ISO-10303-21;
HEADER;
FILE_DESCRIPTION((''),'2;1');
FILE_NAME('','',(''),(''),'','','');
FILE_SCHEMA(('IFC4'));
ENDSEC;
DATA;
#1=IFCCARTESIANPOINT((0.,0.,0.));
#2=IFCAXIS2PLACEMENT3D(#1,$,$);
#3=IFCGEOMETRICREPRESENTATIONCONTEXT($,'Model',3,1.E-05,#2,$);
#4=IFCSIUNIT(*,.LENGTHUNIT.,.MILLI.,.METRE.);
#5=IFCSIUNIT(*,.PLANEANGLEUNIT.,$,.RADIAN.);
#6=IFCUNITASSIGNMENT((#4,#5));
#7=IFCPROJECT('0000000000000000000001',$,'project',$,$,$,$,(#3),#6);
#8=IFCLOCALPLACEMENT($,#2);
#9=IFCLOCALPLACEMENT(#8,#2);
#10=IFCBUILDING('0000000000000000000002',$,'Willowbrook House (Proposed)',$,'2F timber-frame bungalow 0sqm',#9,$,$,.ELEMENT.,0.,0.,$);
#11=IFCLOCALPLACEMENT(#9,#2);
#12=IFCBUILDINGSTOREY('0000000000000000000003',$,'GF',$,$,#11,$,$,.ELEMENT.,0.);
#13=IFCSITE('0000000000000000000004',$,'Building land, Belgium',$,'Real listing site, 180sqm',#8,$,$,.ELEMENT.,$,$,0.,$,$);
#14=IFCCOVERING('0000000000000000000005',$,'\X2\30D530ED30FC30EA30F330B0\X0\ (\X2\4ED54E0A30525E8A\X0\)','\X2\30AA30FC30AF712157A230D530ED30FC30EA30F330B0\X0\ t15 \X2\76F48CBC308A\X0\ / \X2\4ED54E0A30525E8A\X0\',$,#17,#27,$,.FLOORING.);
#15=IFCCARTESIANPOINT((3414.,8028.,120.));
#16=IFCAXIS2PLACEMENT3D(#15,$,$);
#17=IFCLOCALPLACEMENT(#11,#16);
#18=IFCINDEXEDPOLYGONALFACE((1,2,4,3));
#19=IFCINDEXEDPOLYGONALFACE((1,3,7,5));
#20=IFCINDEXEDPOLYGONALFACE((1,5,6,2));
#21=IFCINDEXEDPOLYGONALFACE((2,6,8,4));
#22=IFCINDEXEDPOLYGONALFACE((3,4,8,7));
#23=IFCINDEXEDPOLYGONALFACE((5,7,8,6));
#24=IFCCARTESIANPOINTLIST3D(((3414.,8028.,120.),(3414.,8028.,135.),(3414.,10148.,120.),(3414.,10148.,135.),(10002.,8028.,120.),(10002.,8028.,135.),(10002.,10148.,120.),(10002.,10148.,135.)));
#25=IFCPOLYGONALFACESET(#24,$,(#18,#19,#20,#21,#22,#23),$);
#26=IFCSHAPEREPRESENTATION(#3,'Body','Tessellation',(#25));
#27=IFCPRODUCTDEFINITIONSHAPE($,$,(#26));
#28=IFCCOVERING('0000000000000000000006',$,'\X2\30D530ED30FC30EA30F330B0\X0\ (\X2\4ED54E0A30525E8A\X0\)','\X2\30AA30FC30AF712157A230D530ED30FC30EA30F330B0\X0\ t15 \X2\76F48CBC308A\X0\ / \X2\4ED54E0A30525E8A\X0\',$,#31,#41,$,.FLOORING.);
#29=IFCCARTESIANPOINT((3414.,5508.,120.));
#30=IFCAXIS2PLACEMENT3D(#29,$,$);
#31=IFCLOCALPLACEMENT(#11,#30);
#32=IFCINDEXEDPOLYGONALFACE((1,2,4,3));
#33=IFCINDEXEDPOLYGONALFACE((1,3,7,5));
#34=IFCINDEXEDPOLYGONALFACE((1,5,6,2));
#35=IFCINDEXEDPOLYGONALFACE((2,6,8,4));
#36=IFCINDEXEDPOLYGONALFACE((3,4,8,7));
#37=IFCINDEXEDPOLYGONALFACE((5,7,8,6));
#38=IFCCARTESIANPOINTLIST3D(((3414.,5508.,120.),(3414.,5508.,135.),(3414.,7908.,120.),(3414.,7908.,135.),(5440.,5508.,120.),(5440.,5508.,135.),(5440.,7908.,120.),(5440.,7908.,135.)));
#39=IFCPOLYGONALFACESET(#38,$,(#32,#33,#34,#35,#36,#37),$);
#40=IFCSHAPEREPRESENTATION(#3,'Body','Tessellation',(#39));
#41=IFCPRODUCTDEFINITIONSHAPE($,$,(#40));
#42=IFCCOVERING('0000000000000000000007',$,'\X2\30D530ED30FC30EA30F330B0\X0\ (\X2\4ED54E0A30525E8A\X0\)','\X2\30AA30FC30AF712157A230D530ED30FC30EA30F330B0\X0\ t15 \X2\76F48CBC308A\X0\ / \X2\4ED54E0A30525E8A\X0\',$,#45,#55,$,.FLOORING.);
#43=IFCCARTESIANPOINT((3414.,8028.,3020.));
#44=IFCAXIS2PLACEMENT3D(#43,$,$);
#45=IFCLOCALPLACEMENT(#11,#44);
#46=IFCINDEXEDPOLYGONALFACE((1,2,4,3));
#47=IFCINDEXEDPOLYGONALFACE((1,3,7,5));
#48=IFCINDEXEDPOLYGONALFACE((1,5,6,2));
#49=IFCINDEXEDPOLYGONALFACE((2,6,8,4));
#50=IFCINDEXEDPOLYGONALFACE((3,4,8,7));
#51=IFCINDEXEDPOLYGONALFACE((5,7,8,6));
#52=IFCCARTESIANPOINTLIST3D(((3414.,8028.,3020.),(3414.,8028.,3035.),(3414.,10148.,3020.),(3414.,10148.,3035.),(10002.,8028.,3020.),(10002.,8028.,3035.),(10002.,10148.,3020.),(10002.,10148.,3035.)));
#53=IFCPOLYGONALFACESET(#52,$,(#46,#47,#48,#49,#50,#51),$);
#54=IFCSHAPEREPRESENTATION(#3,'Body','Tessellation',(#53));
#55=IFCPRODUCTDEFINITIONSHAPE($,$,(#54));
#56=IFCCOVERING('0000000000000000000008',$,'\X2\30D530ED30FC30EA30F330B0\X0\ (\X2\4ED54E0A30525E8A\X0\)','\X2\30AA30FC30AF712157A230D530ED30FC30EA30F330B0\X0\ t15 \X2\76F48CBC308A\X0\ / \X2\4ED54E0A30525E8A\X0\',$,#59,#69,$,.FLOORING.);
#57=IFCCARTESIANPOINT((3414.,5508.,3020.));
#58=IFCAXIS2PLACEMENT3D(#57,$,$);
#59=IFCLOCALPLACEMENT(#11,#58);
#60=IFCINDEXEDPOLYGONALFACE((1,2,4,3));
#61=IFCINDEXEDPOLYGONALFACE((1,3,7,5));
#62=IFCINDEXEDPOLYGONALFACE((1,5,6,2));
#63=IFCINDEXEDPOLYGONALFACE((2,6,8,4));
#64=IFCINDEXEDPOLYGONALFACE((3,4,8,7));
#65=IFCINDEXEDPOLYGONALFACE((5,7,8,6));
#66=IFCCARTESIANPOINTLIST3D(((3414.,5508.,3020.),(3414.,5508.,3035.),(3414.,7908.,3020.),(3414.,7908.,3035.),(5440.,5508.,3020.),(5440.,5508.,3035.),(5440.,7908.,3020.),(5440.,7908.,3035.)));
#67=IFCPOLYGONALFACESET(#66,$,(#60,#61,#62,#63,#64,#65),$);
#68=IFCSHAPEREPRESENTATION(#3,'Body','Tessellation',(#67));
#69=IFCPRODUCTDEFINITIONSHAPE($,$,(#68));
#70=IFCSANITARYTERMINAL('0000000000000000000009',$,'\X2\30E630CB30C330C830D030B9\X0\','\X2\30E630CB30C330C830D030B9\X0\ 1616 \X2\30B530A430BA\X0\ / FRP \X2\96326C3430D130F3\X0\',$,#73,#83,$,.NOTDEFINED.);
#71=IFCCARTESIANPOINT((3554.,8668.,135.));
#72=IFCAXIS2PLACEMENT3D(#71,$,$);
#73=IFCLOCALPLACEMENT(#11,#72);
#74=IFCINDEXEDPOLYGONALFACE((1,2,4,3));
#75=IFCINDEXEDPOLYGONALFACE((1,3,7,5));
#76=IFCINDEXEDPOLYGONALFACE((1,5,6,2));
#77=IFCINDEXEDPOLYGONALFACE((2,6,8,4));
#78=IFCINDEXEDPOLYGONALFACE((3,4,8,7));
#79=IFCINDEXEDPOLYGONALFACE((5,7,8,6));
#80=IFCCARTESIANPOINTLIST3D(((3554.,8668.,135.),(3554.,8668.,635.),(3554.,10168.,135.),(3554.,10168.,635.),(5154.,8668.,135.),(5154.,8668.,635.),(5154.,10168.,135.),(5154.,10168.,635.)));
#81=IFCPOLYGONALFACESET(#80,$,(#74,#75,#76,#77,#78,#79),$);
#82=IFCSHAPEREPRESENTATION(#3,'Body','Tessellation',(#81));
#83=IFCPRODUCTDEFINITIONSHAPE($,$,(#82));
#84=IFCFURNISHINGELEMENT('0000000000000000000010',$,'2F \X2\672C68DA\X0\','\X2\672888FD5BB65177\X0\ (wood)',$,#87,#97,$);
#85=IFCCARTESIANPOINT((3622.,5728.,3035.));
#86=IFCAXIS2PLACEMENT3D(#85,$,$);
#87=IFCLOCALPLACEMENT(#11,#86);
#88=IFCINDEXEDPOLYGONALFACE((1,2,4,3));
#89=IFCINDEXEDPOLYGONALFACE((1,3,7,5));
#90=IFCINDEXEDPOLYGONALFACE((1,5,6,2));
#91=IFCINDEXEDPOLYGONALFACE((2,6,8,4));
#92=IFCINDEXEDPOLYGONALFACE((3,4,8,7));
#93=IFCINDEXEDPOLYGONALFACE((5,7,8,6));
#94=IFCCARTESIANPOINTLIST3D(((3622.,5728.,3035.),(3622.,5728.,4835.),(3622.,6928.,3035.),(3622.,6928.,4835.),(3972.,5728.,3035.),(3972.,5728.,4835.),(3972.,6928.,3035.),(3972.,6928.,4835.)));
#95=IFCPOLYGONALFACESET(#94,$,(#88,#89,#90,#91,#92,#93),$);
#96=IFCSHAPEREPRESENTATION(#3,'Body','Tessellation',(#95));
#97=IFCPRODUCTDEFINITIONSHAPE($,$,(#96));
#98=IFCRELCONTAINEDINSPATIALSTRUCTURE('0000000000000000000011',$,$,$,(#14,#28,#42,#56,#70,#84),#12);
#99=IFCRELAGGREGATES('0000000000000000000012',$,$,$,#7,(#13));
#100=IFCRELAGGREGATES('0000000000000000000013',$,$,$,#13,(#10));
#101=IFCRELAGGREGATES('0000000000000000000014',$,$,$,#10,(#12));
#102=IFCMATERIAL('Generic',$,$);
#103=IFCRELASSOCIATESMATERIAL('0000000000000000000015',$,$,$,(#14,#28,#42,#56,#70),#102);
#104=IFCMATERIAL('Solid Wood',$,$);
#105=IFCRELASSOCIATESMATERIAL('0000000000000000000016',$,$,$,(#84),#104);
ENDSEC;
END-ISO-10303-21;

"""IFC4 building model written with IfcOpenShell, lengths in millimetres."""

from ifc_helpers import new_model, si_unit, frame, frame_2d, origin, place, context, project, spatial, rectangle, extrude, material, element, save


model = new_model("IFC4")

# Units and contexts
model_context = context("Model", 3, precision=1e-05, world=origin())
ifc_project = project(units=[si_unit("LENGTHUNIT", "METRE", prefix="MILLI"), si_unit("PLANEANGLEUNIT", "RADIAN")], contexts=[model_context])

# Site, building, storey
site_placement = place(None, origin())
site = spatial("IfcSite", under=ifc_project, at=site_placement, Name="Building land, Belgium", ObjectType="Real listing site, 180sqm", CompositionType="ELEMENT", RefElevation=0.0)
building_placement = place(site_placement, origin())
building = spatial("IfcBuilding", under=site, at=building_placement, Name="Willowbrook House (Proposed)", ObjectType="2F timber-frame bungalow 0sqm", CompositionType="ELEMENT", ElevationOfRefHeight=0.0, ElevationOfTerrain=0.0)
storey_placement = place(building_placement, origin())
storey = spatial("IfcBuildingStorey", under=building, at=storey_placement, Name="GF", CompositionType="ELEMENT", Elevation=0.0)

# Shared definitions
ifc_material_1 = material(Name="Solid Wood")

# Coverings
ifc_material_2 = material(Name="Generic")
covering_1_placement = place(storey_placement, frame((3414.0, 8028.0, 120.0)))
element("IfcCovering", 1, at=covering_1_placement, inside=storey, material=ifc_material_2, Name="フローリング (仕上げ床)", Description="オーク無垢フローリング t15 直貼り / 仕上げ床", PredefinedType="FLOORING", context=model_context, shape_type="SweptSolid", body=[
    extrude(rectangle(XDim=6588.0, YDim=2120.0, at=frame_2d((3294.0, 1060.0))), frame((3414.0, 8028.0, 120.0)), (0.0, 0.0, 1.0), 15.0),
])
covering_2_placement = place(storey_placement, frame((3414.0, 5508.0, 120.0)))
element("IfcCovering", 2, at=covering_2_placement, inside=storey, material=ifc_material_2, Name="フローリング (仕上げ床)", Description="オーク無垢フローリング t15 直貼り / 仕上げ床", PredefinedType="FLOORING", context=model_context, shape_type="SweptSolid", body=[
    extrude(rectangle(XDim=2026.0, YDim=2400.0, at=frame_2d((1013.0, 1200.0))), frame((3414.0, 5508.0, 120.0)), (0.0, 0.0, 1.0), 15.0),
])
covering_3_placement = place(storey_placement, frame((3414.0, 8028.0, 3020.0)))
element("IfcCovering", 3, at=covering_3_placement, inside=storey, material=ifc_material_2, Name="フローリング (仕上げ床)", Description="オーク無垢フローリング t15 直貼り / 仕上げ床", PredefinedType="FLOORING", context=model_context, shape_type="SweptSolid", body=[
    extrude(rectangle(XDim=6588.0, YDim=2120.0, at=frame_2d((3294.0, 1060.0))), frame((3414.0, 8028.0, 3020.0)), (0.0, 0.0, 1.0), 15.0),
])
covering_4_placement = place(storey_placement, frame((3414.0, 5508.0, 3020.0)))
element("IfcCovering", 4, at=covering_4_placement, inside=storey, material=ifc_material_2, Name="フローリング (仕上げ床)", Description="オーク無垢フローリング t15 直貼り / 仕上げ床", PredefinedType="FLOORING", context=model_context, shape_type="SweptSolid", body=[
    extrude(rectangle(XDim=2026.0, YDim=2400.0, at=frame_2d((1013.0, 1200.0))), frame((3414.0, 5508.0, 3020.0)), (0.0, 0.0, 1.0), 15.0),
])

# Sanitary terminal
sanitary_terminal_placement = place(storey_placement, frame((3554.0, 8668.0, 135.0)))
element("IfcSanitaryTerminal", 5, at=sanitary_terminal_placement, inside=storey, material=ifc_material_2, Name="ユニットバス", Description="ユニットバス 1616 サイズ / FRP 防水パン", PredefinedType="NOTDEFINED", context=model_context, shape_type="SweptSolid", body=[
    extrude(rectangle(XDim=1600.0, YDim=1500.0, at=frame_2d((800.0, 750.0))), frame((3554.0, 8668.0, 135.0)), (0.0, 0.0, 1.0), 500.0),
])

# Furnishing element
furnishing_placement = place(storey_placement, frame((3622.0, 5728.0, 3035.0)))
element("IfcFurnishingElement", 6, at=furnishing_placement, inside=storey, material=ifc_material_1, Name="2F 本棚", Description="木製家具 (wood)", context=model_context, shape_type="SweptSolid", body=[
    extrude(rectangle(XDim=350.0, YDim=1200.0, at=frame_2d((175.0, 600.0))), frame((3622.0, 5728.0, 3035.0)), (0.0, 0.0, 1.0), 1800.0),
])

save(model, "model.ifc")
